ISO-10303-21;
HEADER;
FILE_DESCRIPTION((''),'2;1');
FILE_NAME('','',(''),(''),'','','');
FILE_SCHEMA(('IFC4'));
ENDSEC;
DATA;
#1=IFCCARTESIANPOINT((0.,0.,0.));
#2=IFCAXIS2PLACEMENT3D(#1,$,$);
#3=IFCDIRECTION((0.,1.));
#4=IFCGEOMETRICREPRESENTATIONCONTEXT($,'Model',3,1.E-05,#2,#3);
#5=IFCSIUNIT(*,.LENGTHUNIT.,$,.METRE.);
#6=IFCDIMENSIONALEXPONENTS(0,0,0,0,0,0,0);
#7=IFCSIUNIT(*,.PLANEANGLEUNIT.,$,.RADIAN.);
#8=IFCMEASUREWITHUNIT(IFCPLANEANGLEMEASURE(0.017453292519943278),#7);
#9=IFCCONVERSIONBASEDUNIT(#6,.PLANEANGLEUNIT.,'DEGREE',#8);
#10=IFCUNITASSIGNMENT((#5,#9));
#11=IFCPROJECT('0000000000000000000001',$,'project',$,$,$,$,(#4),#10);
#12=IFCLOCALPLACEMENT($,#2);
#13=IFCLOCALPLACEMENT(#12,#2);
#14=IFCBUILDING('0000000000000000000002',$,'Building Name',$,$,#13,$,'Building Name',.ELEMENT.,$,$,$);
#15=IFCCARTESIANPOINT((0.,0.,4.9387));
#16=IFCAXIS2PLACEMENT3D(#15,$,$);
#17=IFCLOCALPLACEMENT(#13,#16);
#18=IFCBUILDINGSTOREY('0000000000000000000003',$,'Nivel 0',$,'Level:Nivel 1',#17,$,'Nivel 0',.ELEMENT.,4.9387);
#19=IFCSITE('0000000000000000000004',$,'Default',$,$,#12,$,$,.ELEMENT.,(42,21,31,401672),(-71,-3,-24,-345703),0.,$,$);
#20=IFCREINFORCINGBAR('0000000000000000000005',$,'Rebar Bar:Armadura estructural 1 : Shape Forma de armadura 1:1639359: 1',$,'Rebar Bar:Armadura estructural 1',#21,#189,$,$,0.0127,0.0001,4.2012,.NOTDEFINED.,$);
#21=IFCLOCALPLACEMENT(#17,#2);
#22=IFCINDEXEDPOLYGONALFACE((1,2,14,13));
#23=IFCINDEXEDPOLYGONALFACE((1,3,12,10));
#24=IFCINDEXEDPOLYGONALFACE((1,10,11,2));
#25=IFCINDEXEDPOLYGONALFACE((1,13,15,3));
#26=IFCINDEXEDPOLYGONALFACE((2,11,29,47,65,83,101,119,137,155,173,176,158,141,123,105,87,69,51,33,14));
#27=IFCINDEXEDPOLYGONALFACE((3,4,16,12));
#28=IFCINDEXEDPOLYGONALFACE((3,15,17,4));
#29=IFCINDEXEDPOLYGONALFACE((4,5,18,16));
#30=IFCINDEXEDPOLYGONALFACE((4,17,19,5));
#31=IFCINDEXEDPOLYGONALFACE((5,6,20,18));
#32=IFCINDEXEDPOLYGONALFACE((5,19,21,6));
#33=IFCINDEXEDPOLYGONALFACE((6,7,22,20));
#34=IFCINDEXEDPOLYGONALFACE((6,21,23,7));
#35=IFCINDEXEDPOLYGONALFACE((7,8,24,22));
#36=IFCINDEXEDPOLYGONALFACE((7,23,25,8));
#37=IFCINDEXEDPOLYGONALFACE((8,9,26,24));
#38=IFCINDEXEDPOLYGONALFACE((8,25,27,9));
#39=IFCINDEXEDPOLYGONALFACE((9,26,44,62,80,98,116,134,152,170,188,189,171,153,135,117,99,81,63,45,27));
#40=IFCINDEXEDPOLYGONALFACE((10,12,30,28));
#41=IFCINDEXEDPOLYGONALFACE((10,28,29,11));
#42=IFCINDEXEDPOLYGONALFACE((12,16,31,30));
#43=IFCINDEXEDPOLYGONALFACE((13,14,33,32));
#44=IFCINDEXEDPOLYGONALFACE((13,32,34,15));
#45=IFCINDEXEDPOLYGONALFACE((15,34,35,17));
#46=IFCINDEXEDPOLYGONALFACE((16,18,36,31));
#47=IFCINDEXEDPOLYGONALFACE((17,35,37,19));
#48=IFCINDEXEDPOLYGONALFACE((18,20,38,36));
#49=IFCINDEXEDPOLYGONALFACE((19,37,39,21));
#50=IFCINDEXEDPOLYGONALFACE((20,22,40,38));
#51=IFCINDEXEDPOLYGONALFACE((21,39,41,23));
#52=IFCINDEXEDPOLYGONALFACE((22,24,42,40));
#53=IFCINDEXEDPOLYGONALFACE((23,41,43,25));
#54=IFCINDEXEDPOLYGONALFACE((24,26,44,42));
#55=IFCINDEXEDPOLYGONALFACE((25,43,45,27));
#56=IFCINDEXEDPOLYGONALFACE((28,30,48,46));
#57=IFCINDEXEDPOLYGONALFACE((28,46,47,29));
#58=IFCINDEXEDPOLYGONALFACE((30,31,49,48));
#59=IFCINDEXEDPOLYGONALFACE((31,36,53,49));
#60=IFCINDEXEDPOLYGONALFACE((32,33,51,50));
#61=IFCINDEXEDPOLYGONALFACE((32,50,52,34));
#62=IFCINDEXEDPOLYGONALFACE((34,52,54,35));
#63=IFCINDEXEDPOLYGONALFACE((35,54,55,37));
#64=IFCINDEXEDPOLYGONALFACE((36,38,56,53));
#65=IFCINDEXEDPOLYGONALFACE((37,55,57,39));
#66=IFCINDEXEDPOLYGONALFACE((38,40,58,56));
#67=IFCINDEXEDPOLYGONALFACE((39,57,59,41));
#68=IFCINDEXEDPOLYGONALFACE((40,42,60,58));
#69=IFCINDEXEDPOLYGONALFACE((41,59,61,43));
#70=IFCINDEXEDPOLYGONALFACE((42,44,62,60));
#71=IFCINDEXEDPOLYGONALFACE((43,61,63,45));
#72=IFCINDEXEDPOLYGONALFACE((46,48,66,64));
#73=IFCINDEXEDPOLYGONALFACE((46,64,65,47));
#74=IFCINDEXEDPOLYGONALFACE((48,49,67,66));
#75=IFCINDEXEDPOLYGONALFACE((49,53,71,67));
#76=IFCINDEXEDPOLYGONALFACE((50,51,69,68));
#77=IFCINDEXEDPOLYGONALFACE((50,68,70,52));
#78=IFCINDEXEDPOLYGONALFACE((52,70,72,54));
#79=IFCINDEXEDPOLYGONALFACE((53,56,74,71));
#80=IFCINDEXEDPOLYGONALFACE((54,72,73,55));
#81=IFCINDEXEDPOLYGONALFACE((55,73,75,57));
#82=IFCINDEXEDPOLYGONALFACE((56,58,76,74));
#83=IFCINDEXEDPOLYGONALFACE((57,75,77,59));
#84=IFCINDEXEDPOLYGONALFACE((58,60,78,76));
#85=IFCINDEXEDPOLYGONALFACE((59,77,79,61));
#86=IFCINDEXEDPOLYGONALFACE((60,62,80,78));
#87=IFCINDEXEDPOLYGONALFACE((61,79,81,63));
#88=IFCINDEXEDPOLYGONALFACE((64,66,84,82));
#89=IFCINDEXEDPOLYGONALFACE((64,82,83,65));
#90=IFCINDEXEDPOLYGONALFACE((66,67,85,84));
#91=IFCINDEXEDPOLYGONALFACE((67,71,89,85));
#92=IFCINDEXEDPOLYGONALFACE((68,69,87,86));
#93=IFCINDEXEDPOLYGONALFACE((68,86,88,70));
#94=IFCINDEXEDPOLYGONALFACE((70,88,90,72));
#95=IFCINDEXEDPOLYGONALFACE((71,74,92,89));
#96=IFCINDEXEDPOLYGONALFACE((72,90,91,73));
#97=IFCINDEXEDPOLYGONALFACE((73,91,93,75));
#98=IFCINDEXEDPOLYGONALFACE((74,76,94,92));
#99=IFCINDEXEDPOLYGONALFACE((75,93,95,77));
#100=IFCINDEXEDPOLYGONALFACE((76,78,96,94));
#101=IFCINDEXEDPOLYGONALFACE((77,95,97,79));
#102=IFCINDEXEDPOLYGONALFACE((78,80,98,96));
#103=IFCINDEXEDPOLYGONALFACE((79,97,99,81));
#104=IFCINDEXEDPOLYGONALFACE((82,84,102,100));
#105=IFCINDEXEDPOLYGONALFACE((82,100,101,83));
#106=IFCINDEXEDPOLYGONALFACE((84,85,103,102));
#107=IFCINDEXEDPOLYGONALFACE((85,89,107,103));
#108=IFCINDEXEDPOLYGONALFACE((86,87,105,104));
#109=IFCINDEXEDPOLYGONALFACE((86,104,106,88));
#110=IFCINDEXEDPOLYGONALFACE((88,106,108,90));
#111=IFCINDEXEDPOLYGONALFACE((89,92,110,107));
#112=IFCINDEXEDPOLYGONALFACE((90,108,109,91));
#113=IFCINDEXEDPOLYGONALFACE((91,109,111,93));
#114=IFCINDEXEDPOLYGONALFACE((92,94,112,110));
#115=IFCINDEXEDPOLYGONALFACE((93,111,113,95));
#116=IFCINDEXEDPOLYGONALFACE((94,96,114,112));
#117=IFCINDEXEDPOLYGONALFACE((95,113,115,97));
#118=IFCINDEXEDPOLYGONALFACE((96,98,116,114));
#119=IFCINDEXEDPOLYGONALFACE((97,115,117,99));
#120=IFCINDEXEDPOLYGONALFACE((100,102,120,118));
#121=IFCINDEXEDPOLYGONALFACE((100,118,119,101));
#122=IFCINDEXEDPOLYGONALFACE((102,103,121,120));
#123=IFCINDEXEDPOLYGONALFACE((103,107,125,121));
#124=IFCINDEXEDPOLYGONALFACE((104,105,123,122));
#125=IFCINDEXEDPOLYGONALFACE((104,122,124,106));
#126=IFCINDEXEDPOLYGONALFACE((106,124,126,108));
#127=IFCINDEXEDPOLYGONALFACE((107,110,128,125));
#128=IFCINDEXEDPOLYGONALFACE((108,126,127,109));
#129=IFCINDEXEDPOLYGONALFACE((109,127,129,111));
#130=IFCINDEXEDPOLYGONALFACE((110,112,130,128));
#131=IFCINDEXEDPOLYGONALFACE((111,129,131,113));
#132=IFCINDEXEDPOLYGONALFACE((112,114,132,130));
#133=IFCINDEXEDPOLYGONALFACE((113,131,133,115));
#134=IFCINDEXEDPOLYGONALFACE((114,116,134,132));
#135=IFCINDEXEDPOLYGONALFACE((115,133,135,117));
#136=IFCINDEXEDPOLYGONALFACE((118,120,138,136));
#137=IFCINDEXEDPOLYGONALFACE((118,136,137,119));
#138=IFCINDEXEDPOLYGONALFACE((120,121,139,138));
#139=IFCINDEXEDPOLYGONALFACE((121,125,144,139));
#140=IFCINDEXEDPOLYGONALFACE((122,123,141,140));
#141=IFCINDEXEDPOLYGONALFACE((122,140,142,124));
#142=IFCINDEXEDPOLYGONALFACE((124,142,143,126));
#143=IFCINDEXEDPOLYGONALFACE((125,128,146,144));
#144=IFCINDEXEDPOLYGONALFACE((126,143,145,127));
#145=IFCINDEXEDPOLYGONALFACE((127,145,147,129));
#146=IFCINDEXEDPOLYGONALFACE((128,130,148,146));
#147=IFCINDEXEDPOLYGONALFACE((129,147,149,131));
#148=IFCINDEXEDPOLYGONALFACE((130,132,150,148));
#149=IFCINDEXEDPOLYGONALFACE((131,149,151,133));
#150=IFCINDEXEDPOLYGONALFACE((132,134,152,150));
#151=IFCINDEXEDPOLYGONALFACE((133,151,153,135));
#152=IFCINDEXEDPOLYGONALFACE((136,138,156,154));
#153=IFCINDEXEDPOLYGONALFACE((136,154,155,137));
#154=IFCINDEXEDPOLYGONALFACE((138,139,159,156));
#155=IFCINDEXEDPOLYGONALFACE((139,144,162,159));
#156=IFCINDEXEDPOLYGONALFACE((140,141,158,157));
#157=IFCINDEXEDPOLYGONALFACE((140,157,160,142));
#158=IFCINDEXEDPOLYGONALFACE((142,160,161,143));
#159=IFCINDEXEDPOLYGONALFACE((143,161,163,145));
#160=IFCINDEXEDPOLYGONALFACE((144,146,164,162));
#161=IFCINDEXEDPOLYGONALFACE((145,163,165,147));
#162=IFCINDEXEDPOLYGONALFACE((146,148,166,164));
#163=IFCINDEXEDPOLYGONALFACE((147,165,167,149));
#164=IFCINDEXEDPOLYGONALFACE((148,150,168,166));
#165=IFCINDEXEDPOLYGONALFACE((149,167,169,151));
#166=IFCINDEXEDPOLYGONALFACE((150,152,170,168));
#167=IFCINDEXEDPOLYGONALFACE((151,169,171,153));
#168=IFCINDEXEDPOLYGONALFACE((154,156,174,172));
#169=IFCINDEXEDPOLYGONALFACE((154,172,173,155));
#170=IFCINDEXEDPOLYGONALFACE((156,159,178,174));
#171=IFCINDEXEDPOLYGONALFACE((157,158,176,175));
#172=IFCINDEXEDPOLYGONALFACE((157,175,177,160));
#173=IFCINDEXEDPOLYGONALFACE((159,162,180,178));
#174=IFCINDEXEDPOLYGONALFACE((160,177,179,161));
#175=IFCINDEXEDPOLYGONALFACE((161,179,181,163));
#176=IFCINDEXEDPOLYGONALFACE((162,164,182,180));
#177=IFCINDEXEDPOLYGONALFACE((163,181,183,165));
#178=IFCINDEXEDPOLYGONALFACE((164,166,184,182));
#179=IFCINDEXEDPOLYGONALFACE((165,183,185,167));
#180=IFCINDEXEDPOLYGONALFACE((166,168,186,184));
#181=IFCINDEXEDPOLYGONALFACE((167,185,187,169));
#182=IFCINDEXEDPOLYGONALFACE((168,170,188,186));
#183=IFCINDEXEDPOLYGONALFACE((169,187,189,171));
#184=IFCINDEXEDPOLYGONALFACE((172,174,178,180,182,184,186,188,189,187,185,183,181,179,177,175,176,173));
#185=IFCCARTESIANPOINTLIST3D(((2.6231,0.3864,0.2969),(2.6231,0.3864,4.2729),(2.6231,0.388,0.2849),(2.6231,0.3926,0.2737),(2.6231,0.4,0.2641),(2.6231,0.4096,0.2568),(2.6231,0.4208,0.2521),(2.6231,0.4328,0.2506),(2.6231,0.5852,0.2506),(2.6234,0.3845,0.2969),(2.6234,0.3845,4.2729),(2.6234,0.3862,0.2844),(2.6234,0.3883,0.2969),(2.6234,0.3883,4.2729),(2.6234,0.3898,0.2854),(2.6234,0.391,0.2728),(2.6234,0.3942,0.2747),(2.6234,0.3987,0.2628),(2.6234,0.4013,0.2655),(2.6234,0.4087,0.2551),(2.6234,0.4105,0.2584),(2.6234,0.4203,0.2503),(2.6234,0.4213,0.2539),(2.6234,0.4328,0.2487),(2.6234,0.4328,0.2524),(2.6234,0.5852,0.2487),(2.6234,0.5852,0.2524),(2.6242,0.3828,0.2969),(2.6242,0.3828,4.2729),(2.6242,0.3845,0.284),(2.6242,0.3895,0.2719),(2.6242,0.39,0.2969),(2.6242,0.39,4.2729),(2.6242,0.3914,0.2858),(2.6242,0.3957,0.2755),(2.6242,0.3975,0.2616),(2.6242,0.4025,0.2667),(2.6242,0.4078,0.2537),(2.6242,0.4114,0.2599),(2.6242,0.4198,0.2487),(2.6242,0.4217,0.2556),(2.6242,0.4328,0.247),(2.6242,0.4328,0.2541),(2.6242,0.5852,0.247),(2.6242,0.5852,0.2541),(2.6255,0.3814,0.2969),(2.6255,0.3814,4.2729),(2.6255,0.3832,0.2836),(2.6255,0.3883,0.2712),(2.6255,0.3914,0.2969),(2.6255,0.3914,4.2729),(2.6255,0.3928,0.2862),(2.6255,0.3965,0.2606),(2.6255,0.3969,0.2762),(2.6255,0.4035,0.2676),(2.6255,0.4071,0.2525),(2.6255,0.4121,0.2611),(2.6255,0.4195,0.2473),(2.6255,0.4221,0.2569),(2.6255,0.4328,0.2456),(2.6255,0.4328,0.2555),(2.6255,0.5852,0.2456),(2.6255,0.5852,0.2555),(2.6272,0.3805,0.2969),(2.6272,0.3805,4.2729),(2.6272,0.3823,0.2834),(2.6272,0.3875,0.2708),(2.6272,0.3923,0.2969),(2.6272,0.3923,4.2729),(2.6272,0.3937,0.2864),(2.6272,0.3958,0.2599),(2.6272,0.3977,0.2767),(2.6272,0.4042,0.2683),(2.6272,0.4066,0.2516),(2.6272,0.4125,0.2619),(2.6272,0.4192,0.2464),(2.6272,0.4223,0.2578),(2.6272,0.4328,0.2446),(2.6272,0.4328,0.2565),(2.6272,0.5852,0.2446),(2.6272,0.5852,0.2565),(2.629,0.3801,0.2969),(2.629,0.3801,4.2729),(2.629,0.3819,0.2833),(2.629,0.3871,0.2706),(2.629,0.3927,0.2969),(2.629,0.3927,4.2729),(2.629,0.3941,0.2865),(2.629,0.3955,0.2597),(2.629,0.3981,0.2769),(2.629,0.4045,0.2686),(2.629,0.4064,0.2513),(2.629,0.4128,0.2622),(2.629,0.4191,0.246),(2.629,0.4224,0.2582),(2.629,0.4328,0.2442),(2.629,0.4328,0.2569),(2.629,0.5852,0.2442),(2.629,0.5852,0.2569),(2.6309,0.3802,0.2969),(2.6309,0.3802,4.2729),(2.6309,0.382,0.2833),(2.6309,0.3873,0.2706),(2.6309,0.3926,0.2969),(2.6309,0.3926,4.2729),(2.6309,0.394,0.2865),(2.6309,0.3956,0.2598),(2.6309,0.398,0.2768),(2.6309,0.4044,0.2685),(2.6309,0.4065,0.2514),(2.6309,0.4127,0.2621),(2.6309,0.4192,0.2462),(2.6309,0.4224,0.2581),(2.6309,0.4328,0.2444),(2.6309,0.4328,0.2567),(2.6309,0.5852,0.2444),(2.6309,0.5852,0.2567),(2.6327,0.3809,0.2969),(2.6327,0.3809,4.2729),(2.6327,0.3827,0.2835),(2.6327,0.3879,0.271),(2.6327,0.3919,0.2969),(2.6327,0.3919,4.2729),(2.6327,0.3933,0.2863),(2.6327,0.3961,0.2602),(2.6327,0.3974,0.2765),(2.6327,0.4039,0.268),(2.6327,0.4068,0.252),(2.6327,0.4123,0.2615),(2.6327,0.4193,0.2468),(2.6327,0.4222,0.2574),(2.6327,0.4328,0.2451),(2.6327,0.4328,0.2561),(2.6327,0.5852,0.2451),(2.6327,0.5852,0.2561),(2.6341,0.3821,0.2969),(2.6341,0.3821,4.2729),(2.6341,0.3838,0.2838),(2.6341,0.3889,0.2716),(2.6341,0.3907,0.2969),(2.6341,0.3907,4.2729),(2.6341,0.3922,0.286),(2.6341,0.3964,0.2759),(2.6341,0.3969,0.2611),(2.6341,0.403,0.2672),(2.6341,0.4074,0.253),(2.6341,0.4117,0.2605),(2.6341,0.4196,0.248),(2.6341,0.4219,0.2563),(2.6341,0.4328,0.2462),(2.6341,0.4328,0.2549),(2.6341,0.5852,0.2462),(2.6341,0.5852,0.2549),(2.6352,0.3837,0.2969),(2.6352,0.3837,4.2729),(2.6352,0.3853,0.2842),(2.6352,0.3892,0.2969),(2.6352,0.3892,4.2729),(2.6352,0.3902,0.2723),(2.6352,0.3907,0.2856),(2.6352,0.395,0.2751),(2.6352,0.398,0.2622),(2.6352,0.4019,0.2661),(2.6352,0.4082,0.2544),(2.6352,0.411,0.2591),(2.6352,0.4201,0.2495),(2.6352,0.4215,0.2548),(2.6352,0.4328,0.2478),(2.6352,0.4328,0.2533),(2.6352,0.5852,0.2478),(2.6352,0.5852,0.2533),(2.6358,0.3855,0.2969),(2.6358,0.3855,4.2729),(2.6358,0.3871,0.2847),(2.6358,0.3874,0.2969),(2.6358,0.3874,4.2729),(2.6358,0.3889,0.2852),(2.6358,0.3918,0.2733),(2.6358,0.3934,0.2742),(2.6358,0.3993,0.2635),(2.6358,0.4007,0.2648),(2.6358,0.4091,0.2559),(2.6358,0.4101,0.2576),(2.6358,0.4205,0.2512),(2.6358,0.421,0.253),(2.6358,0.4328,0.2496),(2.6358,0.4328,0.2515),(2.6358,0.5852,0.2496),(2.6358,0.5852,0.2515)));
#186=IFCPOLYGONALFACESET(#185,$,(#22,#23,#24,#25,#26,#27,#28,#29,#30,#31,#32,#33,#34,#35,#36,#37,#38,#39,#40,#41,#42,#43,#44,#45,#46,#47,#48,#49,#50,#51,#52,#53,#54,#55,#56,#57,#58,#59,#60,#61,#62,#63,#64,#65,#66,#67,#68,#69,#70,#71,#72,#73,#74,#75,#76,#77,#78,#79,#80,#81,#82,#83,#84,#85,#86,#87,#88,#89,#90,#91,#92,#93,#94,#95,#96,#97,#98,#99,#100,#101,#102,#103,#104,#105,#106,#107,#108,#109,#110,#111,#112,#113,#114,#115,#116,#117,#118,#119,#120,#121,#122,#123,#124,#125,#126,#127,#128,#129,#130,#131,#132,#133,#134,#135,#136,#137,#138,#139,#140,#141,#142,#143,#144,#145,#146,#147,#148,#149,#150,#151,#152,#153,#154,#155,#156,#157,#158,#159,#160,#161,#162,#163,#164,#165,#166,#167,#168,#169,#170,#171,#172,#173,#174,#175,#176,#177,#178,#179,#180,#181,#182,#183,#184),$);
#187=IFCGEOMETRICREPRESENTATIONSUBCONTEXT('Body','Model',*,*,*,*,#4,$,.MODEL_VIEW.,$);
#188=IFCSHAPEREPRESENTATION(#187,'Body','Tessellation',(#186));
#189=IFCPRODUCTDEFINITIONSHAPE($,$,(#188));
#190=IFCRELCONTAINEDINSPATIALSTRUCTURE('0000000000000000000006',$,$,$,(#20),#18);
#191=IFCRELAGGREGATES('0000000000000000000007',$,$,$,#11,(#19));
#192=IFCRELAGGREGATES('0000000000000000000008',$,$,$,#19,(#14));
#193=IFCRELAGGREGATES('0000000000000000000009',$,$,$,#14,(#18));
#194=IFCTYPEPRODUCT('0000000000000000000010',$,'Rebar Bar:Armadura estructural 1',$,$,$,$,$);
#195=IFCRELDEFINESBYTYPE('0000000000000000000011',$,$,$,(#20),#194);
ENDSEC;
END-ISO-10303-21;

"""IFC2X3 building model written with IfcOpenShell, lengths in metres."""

from ifc_helpers import new_model, entity, si_unit, converted_unit, direction, frame, origin, place, context, subcontext, project, spatial, type_object, element, save


model = new_model("IFC2X3")

# Units and contexts
model_context = context("Model", 3, precision=1e-05, world=origin(), true_north=direction((0.0, 1.0)))
body_context = subcontext(model_context, "Body", "Model", "MODEL_VIEW")
ifc_project = project(units=[si_unit("LENGTHUNIT", "METRE"), converted_unit("PLANEANGLEUNIT", "DEGREE", entity("IfcPlaneAngleMeasure", 0.017453292519943278), si_unit("PLANEANGLEUNIT", "RADIAN"), dimensions=[0, 0, 0, 0, 0, 0, 0])], contexts=[model_context])

# Site, building, storey
site_placement = place(None, origin())
site = spatial("IfcSite", under=ifc_project, at=site_placement, Name="Default", CompositionType="ELEMENT", RefLatitude=(42, 21, 31, 401672), RefLongitude=(-71, -3, -24, -345703), RefElevation=0.0)
building_placement = place(site_placement, origin())
building = spatial("IfcBuilding", under=site, at=building_placement, Name="Building Name", LongName="Building Name", CompositionType="ELEMENT")
storey_placement = place(building_placement, frame((0.0, 0.0, 4.9387)))
storey = spatial("IfcBuildingStorey", under=building, at=storey_placement, Name="Nivel 0", ObjectType="Level:Nivel 1", LongName="Nivel 0", CompositionType="ELEMENT", Elevation=4.9387)

# Reinforcing bar
type_product = type_object("IfcTypeProduct", Name="Rebar Bar:Armadura estructural 1")
reinforcing_bar_1_placement = place(storey_placement, origin())
element("IfcReinforcingBar", 1, at=reinforcing_bar_1_placement, inside=storey, type_object=type_product, Name="Rebar Bar:Armadura estructural 1 : Shape Forma de armadura 1:1639359: 1", ObjectType="Rebar Bar:Armadura estructural 1", BarLength=4.2012, BarRole="NOTDEFINED", CrossSectionArea=0.0001, NominalDiameter=0.0127, context=body_context, shape_type="AdvancedSweptSolid", body=[
    entity("IfcSweptDiskSolid", entity("IfcCompositeCurve", [entity("IfcCompositeCurveSegment", "CONTINUOUS", True, entity("IfcPolyline", [entity("IfcCartesianPoint", [2.6295, 0.5852, 0.2506]), entity("IfcCartesianPoint", [2.6295, 0.4328, 0.2506])])), entity("IfcCompositeCurveSegment", "CONTINUOUS", True, entity("IfcTrimmedCurve", entity("IfcCircle", entity("IfcAxis2Placement3D", entity("IfcCartesianPoint", [2.6295, 0.4328, 0.2969]), entity("IfcDirection", [-1.0, 0.0, 0.0]), entity("IfcDirection", [0.0, -1.0, 0.0])), 0.0464), [entity("IfcParameterValue", 270.0)], [entity("IfcParameterValue", 360.0)], True, "PARAMETER")), entity("IfcCompositeCurveSegment", "CONTINUOUS", True, entity("IfcPolyline", [entity("IfcCartesianPoint", [2.6295, 0.3864, 0.2969]), entity("IfcCartesianPoint", [2.6295, 0.3864, 4.2729])]))], False), 0.0063, None, 0.0, 92.0),
])

save(model, "model.ifc")
